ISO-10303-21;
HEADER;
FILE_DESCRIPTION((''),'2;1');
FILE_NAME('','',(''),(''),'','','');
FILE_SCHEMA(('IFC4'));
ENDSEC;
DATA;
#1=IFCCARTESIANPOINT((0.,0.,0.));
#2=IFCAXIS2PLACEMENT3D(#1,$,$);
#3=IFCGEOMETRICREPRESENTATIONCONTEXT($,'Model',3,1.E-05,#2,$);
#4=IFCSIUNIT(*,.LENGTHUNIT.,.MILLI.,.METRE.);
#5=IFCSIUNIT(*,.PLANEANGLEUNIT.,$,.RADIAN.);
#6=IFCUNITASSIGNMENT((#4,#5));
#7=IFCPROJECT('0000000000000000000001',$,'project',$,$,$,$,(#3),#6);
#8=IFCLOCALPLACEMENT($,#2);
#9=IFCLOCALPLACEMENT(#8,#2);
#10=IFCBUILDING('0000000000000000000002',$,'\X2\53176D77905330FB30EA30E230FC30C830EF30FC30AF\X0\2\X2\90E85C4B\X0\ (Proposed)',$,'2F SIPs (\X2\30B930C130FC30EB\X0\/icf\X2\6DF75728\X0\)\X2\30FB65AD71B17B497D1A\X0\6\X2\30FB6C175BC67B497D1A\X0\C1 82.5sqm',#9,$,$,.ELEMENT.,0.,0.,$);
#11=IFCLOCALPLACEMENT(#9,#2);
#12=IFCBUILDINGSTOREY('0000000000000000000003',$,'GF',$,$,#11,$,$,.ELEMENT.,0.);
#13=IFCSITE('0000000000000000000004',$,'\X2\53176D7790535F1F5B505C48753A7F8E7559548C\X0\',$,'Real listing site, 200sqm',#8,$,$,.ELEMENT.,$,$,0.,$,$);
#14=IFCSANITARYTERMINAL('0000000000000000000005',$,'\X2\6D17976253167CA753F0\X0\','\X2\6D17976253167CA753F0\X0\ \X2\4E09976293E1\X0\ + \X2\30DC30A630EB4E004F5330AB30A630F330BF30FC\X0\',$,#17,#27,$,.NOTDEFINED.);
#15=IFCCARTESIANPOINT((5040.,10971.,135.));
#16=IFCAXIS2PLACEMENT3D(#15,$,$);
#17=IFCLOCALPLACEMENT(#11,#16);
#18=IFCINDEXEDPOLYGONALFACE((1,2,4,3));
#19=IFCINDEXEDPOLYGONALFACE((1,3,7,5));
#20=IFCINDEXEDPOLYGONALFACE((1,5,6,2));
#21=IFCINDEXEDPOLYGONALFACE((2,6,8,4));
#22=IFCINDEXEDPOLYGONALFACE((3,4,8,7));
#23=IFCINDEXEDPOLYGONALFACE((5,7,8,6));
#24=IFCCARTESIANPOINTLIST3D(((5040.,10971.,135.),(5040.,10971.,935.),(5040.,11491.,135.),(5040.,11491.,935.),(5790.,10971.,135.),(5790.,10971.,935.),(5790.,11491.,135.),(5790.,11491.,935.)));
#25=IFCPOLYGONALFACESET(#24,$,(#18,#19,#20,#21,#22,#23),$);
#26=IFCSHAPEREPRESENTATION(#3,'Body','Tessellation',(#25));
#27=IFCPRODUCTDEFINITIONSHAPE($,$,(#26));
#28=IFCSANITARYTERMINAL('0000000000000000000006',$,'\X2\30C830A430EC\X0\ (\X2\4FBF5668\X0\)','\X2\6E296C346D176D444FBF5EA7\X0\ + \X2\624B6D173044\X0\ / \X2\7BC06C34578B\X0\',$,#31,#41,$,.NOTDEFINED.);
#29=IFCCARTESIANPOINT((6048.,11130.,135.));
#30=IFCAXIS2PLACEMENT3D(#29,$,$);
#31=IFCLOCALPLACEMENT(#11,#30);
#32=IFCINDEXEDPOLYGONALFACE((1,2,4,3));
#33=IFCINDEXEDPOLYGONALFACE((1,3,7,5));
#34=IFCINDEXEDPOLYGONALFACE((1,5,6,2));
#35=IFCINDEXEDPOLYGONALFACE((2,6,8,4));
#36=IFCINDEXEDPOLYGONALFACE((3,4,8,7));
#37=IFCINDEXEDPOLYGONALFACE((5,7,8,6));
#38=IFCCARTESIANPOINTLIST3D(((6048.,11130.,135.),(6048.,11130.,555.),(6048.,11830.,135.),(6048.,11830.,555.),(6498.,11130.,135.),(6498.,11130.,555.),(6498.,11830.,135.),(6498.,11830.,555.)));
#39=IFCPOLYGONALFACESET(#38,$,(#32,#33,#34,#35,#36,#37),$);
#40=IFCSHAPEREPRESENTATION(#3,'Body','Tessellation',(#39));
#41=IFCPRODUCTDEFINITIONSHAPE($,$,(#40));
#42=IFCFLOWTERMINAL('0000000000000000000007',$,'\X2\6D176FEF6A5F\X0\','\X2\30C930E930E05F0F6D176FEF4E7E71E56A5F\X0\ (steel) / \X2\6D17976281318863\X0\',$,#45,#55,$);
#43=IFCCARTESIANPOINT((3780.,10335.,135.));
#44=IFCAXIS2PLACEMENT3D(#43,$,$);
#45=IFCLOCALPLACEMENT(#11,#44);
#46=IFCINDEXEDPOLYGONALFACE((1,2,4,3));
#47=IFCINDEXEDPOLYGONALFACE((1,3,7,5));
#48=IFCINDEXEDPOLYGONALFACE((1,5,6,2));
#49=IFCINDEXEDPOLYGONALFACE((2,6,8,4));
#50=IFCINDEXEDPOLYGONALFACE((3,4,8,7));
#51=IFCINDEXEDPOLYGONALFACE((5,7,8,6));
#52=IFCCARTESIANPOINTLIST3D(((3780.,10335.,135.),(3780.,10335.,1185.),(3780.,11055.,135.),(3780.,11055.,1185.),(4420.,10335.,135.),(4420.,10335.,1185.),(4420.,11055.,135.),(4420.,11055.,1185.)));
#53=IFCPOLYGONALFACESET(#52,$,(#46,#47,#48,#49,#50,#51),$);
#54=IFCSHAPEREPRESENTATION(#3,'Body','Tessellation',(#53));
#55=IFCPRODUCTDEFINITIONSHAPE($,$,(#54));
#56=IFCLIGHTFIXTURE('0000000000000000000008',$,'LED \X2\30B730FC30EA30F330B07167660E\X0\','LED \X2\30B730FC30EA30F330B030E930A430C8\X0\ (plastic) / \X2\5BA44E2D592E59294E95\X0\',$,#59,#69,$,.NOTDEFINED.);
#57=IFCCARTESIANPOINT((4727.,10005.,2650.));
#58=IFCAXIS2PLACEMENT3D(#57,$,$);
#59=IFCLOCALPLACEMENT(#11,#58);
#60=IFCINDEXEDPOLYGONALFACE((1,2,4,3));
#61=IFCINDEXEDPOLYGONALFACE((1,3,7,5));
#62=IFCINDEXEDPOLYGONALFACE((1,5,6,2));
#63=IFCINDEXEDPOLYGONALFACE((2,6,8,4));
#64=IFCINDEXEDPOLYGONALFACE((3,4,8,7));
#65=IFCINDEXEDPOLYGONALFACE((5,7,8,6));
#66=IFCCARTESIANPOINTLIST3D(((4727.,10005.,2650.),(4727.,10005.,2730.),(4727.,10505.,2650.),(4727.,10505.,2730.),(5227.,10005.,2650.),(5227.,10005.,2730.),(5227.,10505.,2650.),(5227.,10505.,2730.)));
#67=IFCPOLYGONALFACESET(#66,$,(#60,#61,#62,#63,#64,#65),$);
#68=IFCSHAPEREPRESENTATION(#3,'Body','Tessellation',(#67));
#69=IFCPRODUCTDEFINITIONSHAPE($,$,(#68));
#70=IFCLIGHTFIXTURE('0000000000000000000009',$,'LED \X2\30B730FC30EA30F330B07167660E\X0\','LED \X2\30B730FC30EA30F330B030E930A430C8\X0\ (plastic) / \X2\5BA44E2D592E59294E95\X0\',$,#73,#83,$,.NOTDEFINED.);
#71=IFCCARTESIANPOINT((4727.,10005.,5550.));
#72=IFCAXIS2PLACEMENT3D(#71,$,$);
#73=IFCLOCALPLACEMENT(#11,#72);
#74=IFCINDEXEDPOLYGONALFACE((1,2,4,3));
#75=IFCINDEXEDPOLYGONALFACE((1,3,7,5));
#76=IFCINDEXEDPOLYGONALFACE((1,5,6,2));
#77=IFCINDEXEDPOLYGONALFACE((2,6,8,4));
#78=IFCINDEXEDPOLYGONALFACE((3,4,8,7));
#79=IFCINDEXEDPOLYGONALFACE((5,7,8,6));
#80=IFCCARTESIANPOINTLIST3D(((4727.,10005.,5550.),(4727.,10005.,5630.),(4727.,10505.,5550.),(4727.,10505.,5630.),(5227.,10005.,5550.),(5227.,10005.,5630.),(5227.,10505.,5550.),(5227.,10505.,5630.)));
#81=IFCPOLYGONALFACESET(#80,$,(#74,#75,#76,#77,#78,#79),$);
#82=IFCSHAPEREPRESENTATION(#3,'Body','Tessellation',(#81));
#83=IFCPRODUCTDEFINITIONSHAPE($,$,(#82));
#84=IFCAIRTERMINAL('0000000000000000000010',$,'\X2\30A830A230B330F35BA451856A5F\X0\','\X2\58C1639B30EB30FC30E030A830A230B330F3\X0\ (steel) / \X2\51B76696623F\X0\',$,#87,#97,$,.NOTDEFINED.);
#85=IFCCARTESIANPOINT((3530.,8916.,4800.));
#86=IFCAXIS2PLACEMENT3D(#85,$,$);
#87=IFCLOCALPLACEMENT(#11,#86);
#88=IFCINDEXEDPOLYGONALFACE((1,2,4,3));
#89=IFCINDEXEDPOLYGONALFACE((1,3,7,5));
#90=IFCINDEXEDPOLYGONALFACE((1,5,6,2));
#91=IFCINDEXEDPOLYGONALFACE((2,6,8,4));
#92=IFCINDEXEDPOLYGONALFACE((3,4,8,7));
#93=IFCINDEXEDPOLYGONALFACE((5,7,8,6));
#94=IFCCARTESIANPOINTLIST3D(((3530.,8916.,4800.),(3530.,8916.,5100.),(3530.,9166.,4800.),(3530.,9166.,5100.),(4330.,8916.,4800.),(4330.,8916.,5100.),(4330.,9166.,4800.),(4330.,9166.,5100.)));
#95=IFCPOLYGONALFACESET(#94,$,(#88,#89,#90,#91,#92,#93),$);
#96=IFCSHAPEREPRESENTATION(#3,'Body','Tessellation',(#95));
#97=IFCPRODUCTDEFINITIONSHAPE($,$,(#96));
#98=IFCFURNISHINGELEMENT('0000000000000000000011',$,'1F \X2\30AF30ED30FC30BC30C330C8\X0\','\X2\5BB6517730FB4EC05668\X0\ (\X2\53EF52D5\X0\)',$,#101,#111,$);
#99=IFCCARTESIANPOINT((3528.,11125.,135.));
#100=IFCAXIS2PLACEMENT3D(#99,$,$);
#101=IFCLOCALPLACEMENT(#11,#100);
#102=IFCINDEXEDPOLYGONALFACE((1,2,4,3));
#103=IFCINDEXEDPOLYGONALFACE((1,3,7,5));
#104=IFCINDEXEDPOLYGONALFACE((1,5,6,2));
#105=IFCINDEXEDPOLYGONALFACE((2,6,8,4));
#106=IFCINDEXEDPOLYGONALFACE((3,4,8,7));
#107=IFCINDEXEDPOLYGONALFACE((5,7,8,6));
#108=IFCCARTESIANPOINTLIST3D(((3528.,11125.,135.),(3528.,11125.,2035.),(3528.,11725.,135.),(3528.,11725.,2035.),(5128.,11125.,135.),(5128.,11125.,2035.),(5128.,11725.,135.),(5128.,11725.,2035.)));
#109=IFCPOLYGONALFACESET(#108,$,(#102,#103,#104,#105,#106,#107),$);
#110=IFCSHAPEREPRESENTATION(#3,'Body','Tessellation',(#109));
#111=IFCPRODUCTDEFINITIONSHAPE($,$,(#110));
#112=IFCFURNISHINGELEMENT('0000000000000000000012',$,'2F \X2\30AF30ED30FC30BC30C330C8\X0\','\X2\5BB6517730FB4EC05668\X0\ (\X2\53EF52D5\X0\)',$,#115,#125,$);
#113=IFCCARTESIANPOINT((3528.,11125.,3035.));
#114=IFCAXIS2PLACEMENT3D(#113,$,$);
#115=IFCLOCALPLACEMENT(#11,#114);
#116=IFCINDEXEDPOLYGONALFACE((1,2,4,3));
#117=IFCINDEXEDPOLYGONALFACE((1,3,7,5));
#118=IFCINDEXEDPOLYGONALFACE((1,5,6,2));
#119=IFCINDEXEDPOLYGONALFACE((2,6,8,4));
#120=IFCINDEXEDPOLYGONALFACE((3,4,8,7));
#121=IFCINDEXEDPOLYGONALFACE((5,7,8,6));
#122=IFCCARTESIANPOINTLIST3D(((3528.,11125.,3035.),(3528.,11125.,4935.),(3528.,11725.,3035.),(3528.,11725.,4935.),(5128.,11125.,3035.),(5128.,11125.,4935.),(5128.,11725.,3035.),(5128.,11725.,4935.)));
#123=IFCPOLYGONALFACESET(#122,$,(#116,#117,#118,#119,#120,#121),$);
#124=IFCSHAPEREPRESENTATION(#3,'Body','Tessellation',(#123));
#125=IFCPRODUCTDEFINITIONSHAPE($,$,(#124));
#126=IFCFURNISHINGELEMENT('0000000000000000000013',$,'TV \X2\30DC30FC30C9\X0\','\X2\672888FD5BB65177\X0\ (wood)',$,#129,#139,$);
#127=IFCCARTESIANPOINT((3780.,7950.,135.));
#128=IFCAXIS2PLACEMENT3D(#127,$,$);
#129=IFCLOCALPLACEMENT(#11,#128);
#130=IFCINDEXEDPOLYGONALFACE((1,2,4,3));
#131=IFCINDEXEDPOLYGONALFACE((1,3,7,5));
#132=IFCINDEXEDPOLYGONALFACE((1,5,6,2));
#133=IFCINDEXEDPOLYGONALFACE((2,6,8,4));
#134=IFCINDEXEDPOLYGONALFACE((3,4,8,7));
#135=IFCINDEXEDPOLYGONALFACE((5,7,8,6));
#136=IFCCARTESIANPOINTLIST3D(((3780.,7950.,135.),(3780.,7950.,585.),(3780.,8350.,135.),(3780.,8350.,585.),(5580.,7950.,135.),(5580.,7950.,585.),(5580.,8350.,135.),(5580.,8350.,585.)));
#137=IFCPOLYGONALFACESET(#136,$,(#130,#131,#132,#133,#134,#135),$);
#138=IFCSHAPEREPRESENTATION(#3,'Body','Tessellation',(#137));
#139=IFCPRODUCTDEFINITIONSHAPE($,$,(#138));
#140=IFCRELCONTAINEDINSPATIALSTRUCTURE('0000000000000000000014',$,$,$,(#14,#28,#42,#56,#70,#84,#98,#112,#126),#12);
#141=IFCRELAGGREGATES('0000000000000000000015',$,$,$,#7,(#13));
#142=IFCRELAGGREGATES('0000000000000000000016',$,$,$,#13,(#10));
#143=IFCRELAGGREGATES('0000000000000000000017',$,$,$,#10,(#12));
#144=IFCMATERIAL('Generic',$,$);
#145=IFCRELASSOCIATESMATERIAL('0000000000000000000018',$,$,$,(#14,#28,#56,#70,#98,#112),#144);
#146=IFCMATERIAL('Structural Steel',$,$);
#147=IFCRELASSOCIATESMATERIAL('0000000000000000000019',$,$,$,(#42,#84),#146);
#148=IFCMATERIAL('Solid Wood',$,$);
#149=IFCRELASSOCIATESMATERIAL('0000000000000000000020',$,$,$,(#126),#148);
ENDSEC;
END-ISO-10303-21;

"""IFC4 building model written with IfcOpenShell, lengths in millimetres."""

from ifc_helpers import new_model, si_unit, frame, frame_2d, origin, place, context, project, spatial, rectangle, extrude, material, element, save


model = new_model("IFC4")

# Units and contexts
model_context = context("Model", 3, precision=1e-05, world=origin())
ifc_project = project(units=[si_unit("LENGTHUNIT", "METRE", prefix="MILLI"), si_unit("PLANEANGLEUNIT", "RADIAN")], contexts=[model_context])

# Site, building, storey
site_placement = place(None, origin())
site = spatial("IfcSite", under=ifc_project, at=site_placement, Name="北海道弟子屈町美留和", ObjectType="Real listing site, 200sqm", CompositionType="ELEMENT", RefElevation=0.0)
building_placement = place(site_placement, origin())
building = spatial("IfcBuilding", under=site, at=building_placement, Name="北海道・リモートワーク2部屋 (Proposed)", ObjectType="2F SIPs (スチール/icf混在)・断熱等級6・気密等級C1 82.5sqm", CompositionType="ELEMENT", ElevationOfRefHeight=0.0, ElevationOfTerrain=0.0)
storey_placement = place(building_placement, origin())
storey = spatial("IfcBuildingStorey", under=building, at=storey_placement, Name="GF", CompositionType="ELEMENT", Elevation=0.0)

# Shared definitions
ifc_material_1 = material(Name="Solid Wood")

# Sanitary terminals
ifc_material_2 = material(Name="Generic")
sanitary_terminal_1_placement = place(storey_placement, frame((5040.0, 10971.0, 135.0)))
element("IfcSanitaryTerminal", 1, at=sanitary_terminal_1_placement, inside=storey, material=ifc_material_2, Name="洗面化粧台", Description="洗面化粧台 三面鏡 + ボウル一体カウンター", PredefinedType="NOTDEFINED", context=model_context, shape_type="SweptSolid", body=[
    extrude(rectangle(XDim=750.0, YDim=520.0, at=frame_2d((375.0, 260.0))), frame((5040.0, 10971.0, 135.0)), (0.0, 0.0, 1.0), 800.0),
])
sanitary_terminal_2_placement = place(storey_placement, frame((6048.0, 11130.0, 135.0)))
element("IfcSanitaryTerminal", 2, at=sanitary_terminal_2_placement, inside=storey, material=ifc_material_2, Name="トイレ (便器)", Description="温水洗浄便座 + 手洗い / 節水型", PredefinedType="NOTDEFINED", context=model_context, shape_type="SweptSolid", body=[
    extrude(rectangle(XDim=450.0, YDim=700.0, at=frame_2d((225.0, 350.0))), frame((6048.0, 11130.0, 135.0)), (0.0, 0.0, 1.0), 420.0),
])

# Flow terminal
ifc_material_3 = material(Name="Structural Steel")
flow_terminal_placement = place(storey_placement, frame((3780.0, 10335.0, 135.0)))
element("IfcFlowTerminal", 3, at=flow_terminal_placement, inside=storey, material=ifc_material_3, Name="洗濯機", Description="ドラム式洗濯乾燥機 (steel) / 洗面脱衣", context=model_context, shape_type="SweptSolid", body=[
    extrude(rectangle(XDim=640.0, YDim=720.0, at=frame_2d((320.0, 360.0))), frame((3780.0, 10335.0, 135.0)), (0.0, 0.0, 1.0), 1050.0),
])

# Light fixtures
light_fixture_1_placement = place(storey_placement, frame((4727.0, 10005.0, 2650.0)))
element("IfcLightFixture", 4, at=light_fixture_1_placement, inside=storey, material=ifc_material_2, Name="LED シーリング照明", Description="LED シーリングライト (plastic) / 室中央天井", PredefinedType="NOTDEFINED", context=model_context, shape_type="SweptSolid", body=[
    extrude(rectangle(XDim=500.0, YDim=500.0, at=frame_2d((250.0, 250.0))), frame((4727.0, 10005.0, 2650.0)), (0.0, 0.0, 1.0), 80.0),
])
light_fixture_2_placement = place(storey_placement, frame((4727.0, 10005.0, 5550.0)))
element("IfcLightFixture", 5, at=light_fixture_2_placement, inside=storey, material=ifc_material_2, Name="LED シーリング照明", Description="LED シーリングライト (plastic) / 室中央天井", PredefinedType="NOTDEFINED", context=model_context, shape_type="SweptSolid", body=[
    extrude(rectangle(XDim=500.0, YDim=500.0, at=frame_2d((250.0, 250.0))), frame((4727.0, 10005.0, 5550.0)), (0.0, 0.0, 1.0), 80.0),
])

# Air terminal
air_terminal_placement = place(storey_placement, frame((3530.0, 8916.0, 4800.0)))
element("IfcAirTerminal", 6, at=air_terminal_placement, inside=storey, material=ifc_material_3, Name="エアコン室内機", Description="壁掛ルームエアコン (steel) / 冷暖房", PredefinedType="NOTDEFINED", context=model_context, shape_type="SweptSolid", body=[
    extrude(rectangle(XDim=800.0, YDim=250.0, at=frame_2d((400.0, 125.0))), frame((3530.0, 8916.0, 4800.0)), (0.0, 0.0, 1.0), 300.0),
])

# Furnishing elements
furnishing_1_placement = place(storey_placement, frame((3528.0, 11125.0, 135.0)))
element("IfcFurnishingElement", 7, at=furnishing_1_placement, inside=storey, material=ifc_material_2, Name="1F クローゼット", Description="家具・什器 (可動)", context=model_context, shape_type="SweptSolid", body=[
    extrude(rectangle(XDim=1600.0, YDim=600.0, at=frame_2d((800.0, 300.0))), frame((3528.0, 11125.0, 135.0)), (0.0, 0.0, 1.0), 1900.0),
])
furnishing_2_placement = place(storey_placement, frame((3528.0, 11125.0, 3035.0)))
element("IfcFurnishingElement", 8, at=furnishing_2_placement, inside=storey, material=ifc_material_2, Name="2F クローゼット", Description="家具・什器 (可動)", context=model_context, shape_type="SweptSolid", body=[
    extrude(rectangle(XDim=1600.0, YDim=600.0, at=frame_2d((800.0, 300.0))), frame((3528.0, 11125.0, 3035.0)), (0.0, 0.0, 1.0), 1900.0),
])
furnishing_3_placement = place(storey_placement, frame((3780.0, 7950.0, 135.0)))
element("IfcFurnishingElement", 9, at=furnishing_3_placement, inside=storey, material=ifc_material_1, Name="TV ボード", Description="木製家具 (wood)", context=model_context, shape_type="SweptSolid", body=[
    extrude(rectangle(XDim=1800.0, YDim=400.0, at=frame_2d((900.0, 200.0))), frame((3780.0, 7950.0, 135.0)), (0.0, 0.0, 1.0), 450.0),
])

save(model, "model.ifc")
